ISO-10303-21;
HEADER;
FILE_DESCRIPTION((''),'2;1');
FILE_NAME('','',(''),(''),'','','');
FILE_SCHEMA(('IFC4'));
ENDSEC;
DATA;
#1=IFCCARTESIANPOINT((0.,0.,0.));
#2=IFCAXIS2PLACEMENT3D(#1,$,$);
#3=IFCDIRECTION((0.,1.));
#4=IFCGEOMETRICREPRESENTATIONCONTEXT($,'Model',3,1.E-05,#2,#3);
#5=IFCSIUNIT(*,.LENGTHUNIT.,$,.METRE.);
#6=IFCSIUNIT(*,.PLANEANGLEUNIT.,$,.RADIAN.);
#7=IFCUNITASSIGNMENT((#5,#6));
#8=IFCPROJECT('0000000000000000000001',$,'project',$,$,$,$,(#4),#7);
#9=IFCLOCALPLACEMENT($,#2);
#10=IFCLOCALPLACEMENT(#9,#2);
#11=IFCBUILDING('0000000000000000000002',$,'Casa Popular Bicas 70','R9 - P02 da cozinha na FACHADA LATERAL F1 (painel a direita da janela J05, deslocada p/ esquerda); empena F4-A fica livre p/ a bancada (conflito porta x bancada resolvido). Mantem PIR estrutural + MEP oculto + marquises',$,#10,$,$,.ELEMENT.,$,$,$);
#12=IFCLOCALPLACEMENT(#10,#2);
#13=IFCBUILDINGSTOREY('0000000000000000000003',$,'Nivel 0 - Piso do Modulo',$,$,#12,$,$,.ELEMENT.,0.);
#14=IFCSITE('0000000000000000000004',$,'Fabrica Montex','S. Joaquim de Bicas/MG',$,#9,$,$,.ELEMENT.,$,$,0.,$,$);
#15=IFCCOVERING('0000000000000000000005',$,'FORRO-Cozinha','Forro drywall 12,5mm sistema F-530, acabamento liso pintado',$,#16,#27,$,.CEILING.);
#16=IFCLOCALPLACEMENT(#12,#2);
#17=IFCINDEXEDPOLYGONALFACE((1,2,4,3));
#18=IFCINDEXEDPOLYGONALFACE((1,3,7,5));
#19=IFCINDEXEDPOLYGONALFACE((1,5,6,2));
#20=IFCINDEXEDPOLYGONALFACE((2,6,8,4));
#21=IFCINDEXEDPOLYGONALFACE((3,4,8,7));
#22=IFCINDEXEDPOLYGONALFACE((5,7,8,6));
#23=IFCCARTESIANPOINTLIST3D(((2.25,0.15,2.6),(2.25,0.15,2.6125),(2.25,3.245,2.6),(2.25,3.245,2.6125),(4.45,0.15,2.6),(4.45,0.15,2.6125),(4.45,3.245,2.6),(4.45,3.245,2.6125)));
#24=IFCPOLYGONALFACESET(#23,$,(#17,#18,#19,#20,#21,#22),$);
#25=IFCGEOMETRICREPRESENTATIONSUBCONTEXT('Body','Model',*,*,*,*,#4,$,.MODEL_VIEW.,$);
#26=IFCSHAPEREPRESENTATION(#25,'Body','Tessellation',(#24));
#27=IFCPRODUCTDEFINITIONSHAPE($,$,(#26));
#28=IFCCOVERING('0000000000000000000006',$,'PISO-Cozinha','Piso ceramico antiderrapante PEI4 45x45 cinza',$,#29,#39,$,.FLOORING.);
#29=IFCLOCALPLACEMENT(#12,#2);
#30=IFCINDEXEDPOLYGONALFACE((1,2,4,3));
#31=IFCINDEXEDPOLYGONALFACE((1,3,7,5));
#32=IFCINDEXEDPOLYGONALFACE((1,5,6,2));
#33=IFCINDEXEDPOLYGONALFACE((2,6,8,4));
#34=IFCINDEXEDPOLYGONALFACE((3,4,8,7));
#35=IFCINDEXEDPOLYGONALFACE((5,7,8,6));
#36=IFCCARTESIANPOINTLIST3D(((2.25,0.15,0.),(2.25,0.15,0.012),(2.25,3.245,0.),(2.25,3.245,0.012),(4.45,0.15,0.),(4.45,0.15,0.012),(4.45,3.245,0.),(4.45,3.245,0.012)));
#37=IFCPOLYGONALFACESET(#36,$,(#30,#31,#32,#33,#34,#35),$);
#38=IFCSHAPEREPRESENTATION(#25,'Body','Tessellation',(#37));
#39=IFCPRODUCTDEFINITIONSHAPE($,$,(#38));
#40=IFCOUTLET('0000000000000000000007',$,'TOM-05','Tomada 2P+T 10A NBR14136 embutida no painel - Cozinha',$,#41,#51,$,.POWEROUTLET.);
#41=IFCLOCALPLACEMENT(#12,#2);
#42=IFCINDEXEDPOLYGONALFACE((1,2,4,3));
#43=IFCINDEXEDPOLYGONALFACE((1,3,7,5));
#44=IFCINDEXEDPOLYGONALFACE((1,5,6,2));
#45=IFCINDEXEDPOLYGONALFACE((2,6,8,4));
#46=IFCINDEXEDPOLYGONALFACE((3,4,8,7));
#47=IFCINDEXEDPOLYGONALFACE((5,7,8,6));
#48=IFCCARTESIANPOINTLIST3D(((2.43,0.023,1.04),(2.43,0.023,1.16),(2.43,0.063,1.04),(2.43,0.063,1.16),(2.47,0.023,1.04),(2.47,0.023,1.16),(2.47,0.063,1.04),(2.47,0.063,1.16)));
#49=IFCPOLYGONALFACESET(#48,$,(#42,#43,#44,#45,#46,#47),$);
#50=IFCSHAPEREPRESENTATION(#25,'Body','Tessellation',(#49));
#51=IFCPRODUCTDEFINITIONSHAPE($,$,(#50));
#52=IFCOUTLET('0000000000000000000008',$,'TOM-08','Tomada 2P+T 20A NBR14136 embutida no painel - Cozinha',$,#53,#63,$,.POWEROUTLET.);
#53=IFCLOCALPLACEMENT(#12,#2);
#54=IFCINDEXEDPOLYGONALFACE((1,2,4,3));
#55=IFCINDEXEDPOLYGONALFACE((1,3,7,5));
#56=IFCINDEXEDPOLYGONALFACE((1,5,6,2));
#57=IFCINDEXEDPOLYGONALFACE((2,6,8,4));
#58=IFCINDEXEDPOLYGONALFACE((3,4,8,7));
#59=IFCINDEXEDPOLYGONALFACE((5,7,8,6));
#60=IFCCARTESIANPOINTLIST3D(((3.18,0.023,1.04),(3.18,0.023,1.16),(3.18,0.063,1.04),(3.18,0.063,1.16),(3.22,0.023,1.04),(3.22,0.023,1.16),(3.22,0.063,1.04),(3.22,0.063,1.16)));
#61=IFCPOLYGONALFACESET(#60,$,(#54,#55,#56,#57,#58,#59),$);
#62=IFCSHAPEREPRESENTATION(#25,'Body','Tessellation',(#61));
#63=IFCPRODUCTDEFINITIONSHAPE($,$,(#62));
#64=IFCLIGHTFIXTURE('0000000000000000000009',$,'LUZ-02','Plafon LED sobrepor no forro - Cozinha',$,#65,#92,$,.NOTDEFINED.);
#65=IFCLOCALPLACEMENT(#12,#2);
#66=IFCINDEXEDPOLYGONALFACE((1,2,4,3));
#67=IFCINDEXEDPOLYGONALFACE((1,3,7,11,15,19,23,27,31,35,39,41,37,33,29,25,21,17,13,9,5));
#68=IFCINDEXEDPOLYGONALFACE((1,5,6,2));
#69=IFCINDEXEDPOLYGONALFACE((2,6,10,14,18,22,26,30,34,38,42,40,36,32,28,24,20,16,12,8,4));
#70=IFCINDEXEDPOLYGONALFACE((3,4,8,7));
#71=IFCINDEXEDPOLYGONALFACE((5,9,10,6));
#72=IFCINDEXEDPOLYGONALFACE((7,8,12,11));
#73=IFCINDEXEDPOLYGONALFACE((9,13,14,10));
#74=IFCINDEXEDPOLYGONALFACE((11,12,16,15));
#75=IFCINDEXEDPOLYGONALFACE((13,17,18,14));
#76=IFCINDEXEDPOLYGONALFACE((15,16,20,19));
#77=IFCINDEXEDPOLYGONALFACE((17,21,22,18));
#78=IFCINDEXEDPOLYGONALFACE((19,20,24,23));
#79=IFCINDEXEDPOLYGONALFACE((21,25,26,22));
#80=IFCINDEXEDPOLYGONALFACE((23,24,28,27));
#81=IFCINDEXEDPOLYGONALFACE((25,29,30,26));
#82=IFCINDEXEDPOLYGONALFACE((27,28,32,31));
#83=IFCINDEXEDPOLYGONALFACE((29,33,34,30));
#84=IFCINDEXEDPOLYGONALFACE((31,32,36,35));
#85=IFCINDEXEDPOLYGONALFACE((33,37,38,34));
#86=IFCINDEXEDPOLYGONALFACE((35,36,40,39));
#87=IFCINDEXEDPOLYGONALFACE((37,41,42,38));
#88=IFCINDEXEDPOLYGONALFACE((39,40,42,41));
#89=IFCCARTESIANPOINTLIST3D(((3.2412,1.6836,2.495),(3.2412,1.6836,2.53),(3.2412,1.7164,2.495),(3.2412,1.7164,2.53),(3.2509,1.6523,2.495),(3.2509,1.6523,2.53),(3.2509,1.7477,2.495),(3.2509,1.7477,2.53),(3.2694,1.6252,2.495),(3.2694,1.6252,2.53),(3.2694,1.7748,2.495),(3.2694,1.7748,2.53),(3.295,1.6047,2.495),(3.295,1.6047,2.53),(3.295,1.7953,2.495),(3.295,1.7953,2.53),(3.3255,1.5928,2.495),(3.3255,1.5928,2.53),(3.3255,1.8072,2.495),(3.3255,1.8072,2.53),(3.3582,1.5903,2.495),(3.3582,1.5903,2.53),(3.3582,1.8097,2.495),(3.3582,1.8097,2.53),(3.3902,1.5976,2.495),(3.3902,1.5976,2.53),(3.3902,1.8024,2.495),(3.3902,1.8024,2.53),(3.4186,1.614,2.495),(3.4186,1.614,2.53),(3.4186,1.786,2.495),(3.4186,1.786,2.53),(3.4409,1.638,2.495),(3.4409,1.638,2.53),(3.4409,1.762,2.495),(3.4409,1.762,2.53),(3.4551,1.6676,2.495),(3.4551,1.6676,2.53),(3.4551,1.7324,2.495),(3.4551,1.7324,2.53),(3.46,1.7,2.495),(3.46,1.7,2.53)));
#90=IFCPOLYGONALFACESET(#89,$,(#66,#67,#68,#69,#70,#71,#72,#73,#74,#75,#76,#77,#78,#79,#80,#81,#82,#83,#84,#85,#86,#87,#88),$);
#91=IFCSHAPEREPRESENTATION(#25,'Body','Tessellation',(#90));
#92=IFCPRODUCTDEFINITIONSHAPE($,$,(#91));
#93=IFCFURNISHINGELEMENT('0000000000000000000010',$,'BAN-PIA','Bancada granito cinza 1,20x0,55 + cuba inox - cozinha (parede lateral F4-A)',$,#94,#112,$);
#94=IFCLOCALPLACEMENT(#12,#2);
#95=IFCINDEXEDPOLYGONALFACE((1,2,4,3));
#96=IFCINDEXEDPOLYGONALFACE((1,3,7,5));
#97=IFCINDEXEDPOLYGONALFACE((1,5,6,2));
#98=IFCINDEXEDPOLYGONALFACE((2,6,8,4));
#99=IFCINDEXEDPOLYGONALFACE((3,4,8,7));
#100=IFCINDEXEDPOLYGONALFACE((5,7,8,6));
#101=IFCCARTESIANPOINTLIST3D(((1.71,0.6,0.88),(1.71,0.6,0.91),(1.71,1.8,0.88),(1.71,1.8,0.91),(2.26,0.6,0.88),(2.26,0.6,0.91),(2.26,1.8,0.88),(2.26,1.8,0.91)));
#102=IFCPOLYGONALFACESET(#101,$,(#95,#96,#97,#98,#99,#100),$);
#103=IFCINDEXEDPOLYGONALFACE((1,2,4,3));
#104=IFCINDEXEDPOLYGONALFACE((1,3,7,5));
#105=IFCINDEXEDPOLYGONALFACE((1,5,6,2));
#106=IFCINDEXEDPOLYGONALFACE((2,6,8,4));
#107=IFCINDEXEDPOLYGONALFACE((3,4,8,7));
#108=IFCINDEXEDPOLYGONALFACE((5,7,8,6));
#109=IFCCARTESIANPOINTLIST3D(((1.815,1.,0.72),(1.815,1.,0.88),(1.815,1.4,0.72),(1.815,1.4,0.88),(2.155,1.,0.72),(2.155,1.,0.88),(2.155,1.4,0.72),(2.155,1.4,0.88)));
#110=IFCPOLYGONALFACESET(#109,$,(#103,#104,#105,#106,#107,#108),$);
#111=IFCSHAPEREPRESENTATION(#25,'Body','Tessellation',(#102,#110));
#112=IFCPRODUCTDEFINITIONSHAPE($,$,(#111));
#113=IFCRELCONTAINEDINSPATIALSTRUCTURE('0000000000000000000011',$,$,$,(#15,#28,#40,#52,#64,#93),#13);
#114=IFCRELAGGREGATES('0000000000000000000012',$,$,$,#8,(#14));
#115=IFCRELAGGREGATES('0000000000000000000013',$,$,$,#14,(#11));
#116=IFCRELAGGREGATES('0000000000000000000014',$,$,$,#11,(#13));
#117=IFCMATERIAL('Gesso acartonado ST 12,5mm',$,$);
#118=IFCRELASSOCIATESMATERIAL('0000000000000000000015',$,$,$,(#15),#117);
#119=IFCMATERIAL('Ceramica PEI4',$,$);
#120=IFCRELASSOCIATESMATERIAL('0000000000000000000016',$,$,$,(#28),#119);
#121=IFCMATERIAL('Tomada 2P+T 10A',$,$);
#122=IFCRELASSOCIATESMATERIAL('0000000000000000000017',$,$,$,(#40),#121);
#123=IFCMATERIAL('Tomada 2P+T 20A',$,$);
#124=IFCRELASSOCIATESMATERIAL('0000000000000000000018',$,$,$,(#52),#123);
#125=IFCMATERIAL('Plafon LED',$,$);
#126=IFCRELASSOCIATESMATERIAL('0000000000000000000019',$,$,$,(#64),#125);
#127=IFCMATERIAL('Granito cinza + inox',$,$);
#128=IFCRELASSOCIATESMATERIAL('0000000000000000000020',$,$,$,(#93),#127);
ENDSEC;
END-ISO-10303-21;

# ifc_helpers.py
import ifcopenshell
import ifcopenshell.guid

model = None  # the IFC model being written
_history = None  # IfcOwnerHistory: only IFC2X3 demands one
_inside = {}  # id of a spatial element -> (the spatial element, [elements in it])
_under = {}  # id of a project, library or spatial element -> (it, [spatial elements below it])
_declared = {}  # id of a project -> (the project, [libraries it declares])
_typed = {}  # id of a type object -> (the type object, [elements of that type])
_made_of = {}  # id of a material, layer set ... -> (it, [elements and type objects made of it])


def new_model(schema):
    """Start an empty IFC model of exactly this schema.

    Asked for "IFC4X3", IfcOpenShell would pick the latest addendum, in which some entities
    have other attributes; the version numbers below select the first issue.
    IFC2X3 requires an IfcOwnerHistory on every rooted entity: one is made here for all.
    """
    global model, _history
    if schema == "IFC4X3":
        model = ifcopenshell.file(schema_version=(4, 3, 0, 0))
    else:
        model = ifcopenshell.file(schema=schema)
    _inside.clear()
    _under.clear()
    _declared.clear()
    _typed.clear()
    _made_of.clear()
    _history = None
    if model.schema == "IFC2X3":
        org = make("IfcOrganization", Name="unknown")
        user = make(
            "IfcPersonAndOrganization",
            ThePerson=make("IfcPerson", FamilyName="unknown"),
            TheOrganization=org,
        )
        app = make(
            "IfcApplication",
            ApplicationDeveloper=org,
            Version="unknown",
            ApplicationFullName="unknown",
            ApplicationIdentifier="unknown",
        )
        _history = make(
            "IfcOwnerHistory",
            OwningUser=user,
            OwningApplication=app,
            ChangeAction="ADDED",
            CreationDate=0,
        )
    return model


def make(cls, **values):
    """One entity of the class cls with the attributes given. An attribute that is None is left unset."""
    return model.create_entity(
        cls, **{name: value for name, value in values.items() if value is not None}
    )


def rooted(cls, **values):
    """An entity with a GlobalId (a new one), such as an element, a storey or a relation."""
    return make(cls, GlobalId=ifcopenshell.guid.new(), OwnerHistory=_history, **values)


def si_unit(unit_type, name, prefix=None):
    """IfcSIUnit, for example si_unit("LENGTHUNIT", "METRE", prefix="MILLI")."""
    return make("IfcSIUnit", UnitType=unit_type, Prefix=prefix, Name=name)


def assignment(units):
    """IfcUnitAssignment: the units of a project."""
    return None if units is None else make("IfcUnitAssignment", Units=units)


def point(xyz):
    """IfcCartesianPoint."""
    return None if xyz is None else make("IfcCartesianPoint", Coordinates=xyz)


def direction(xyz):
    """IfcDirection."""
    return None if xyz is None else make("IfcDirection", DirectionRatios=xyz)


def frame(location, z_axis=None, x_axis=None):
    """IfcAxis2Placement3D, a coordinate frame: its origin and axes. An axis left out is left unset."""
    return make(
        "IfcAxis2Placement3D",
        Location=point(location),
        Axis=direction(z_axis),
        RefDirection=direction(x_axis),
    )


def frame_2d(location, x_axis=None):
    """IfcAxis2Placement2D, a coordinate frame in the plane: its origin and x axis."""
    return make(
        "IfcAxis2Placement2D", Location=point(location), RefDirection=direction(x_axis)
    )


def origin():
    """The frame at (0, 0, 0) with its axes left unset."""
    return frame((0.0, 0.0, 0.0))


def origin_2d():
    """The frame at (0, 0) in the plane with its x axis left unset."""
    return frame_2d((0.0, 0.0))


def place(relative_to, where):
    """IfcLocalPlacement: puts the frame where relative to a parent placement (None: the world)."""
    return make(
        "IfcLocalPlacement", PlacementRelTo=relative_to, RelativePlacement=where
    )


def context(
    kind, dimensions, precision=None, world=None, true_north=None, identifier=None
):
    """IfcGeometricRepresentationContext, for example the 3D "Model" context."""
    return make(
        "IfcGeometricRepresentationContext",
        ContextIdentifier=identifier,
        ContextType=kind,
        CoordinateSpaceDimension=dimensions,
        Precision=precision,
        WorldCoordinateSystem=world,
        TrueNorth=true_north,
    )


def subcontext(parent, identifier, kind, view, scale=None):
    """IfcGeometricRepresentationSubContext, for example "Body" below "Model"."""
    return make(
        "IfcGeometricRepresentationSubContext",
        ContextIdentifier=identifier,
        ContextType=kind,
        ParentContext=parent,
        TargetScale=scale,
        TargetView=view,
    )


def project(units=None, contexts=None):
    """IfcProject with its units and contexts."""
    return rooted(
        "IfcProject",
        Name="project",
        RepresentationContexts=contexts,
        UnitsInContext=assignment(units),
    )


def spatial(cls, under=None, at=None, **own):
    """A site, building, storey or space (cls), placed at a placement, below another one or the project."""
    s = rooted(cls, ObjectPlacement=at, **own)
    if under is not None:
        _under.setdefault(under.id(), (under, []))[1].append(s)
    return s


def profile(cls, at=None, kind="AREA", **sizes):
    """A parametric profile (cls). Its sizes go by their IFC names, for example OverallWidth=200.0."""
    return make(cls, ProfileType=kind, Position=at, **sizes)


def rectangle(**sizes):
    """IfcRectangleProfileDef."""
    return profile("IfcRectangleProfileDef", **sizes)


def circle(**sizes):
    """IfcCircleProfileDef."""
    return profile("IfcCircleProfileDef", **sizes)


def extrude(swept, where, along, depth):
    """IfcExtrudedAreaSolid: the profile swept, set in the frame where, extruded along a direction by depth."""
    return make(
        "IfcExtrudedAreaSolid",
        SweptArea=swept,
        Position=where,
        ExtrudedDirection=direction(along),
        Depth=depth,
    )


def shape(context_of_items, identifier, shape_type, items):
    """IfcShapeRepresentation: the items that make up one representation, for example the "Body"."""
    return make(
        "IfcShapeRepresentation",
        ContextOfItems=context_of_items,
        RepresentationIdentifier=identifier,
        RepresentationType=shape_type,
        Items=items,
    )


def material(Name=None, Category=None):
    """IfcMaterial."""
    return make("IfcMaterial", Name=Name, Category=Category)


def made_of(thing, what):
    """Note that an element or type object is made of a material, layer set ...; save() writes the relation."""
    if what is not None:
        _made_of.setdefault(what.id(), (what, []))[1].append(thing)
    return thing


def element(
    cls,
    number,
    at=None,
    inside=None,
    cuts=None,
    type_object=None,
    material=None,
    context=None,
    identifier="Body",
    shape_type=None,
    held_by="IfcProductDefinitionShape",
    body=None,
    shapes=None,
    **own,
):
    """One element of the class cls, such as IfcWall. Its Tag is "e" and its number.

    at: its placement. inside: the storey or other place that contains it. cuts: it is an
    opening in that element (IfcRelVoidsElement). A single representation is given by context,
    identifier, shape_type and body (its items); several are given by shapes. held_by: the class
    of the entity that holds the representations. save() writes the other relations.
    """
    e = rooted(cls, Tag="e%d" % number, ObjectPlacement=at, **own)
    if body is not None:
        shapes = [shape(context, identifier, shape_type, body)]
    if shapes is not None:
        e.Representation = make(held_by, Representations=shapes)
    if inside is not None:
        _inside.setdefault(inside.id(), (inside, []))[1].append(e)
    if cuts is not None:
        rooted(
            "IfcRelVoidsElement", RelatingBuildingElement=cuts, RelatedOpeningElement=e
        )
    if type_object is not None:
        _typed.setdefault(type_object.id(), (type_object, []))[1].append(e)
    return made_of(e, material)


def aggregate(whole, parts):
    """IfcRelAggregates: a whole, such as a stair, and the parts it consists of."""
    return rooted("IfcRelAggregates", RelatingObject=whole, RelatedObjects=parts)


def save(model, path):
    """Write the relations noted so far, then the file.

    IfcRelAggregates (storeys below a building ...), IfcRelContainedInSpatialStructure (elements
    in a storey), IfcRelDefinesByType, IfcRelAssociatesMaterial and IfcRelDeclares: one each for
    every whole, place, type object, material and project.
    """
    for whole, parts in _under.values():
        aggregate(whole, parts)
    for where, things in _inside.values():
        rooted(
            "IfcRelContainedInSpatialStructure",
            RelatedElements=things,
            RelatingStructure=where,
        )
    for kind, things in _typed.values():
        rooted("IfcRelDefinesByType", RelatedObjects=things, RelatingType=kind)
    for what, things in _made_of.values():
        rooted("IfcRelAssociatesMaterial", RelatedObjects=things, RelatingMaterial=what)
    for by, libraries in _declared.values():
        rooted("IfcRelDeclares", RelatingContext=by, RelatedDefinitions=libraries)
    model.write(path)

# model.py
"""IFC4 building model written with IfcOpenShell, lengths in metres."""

from ifc_helpers import new_model, si_unit, direction, frame, frame_2d, origin, origin_2d, place, context, subcontext, project, spatial, rectangle, circle, extrude, material, element, save


model = new_model("IFC4")

# Units and contexts
model_context = context("Model", 3, precision=1e-05, world=origin(), true_north=direction((0.0, 1.0)))
body_context = subcontext(model_context, "Body", "Model", "MODEL_VIEW")
ifc_project = project(units=[si_unit("LENGTHUNIT", "METRE"), si_unit("PLANEANGLEUNIT", "RADIAN")], contexts=[model_context])

# Site, building, storey
site_placement = place(None, origin())
site = spatial("IfcSite", under=ifc_project, at=site_placement, Name="Fabrica Montex", Description="S. Joaquim de Bicas/MG", CompositionType="ELEMENT", RefElevation=0.0)
building_placement = place(site_placement, origin())
building = spatial("IfcBuilding", under=site, at=building_placement, Name="Casa Popular Bicas 70", Description="R9 - P02 da cozinha na FACHADA LATERAL F1 (painel a direita da janela J05, deslocada p/ esquerda); empena F4-A fica livre p/ a bancada (conflito porta x bancada resolvido). Mantem PIR estrutural + MEP oculto + marquises", CompositionType="ELEMENT")
storey_placement = place(building_placement, origin())
storey = spatial("IfcBuildingStorey", under=building, at=storey_placement, Name="Nivel 0 - Piso do Modulo", CompositionType="ELEMENT", Elevation=0.0)

# Coverings
ifc_material_1 = material(Name="Gesso acartonado ST 12,5mm")
covering_1_placement = place(storey_placement, frame((2.25, 0.15, 2.6)))
element("IfcCovering", 1, at=covering_1_placement, inside=storey, material=ifc_material_1, Name="FORRO-Cozinha", Description="Forro drywall 12,5mm sistema F-530, acabamento liso pintado", PredefinedType="CEILING", context=body_context, shape_type="SweptSolid", body=[
    extrude(rectangle(XDim=2.2, YDim=3.095, at=frame_2d((1.1, 1.5475))), origin(), (0.0, 0.0, 1.0), 0.0125),
])
ifc_material_2 = material(Name="Ceramica PEI4")
covering_2_placement = place(storey_placement, frame((2.25, 0.15, 0.0)))
element("IfcCovering", 2, at=covering_2_placement, inside=storey, material=ifc_material_2, Name="PISO-Cozinha", Description="Piso ceramico antiderrapante PEI4 45x45 cinza", PredefinedType="FLOORING", context=body_context, shape_type="SweptSolid", body=[
    extrude(rectangle(XDim=2.2, YDim=3.095, at=frame_2d((1.1, 1.5475))), origin(), (0.0, 0.0, 1.0), 0.012),
])

# Outlets
ifc_material_3 = material(Name="Tomada 2P+T 10A")
outlet_1_placement = place(storey_placement, frame((2.43, 0.023, 1.04)))
element("IfcOutlet", 3, at=outlet_1_placement, inside=storey, material=ifc_material_3, Name="TOM-05", Description="Tomada 2P+T 10A NBR14136 embutida no painel - Cozinha", PredefinedType="POWEROUTLET", context=body_context, shape_type="SweptSolid", body=[
    extrude(rectangle(XDim=0.04, YDim=0.04, at=frame_2d((0.02, 0.02))), origin(), (0.0, 0.0, 1.0), 0.12),
])
ifc_material_4 = material(Name="Tomada 2P+T 20A")
outlet_2_placement = place(storey_placement, frame((3.18, 0.023, 1.04)))
element("IfcOutlet", 4, at=outlet_2_placement, inside=storey, material=ifc_material_4, Name="TOM-08", Description="Tomada 2P+T 20A NBR14136 embutida no painel - Cozinha", PredefinedType="POWEROUTLET", context=body_context, shape_type="SweptSolid", body=[
    extrude(rectangle(XDim=0.04, YDim=0.04, at=frame_2d((0.02, 0.02))), origin(), (0.0, 0.0, 1.0), 0.12),
])

# Light fixture
ifc_material_5 = material(Name="Plafon LED")
light_fixture_placement = place(storey_placement, frame((3.35, 1.7, 2.495)))
element("IfcLightFixture", 5, at=light_fixture_placement, inside=storey, material=ifc_material_5, Name="LUZ-02", Description="Plafon LED sobrepor no forro - Cozinha", PredefinedType="NOTDEFINED", context=body_context, shape_type="SweptSolid", body=[
    extrude(circle(Radius=0.11, at=origin_2d()), origin(), (0.0, 0.0, 1.0), 0.035),
])

# Furnishing element
ifc_material_6 = material(Name="Granito cinza + inox")
furnishing_placement = place(storey_placement, frame((2.26, 0.6, 0.88), x_axis=(0.0, 1.0, 0.0)))
element("IfcFurnishingElement", 6, at=furnishing_placement, inside=storey, material=ifc_material_6, Name="BAN-PIA", Description="Bancada granito cinza 1,20x0,55 + cuba inox - cozinha (parede lateral F4-A)", context=body_context, shape_type="SweptSolid", body=[
    extrude(rectangle(XDim=1.2, YDim=0.55, at=frame_2d((0.6, 0.275))), origin(), (0.0, 0.0, 1.0), 0.03),
    extrude(rectangle(XDim=0.4, YDim=0.34, at=frame_2d((0.6, 0.275))), frame((0.0, 0.0, -0.16)), (0.0, 0.0, 1.0), 0.16),
])

save(model, "model.ifc")
